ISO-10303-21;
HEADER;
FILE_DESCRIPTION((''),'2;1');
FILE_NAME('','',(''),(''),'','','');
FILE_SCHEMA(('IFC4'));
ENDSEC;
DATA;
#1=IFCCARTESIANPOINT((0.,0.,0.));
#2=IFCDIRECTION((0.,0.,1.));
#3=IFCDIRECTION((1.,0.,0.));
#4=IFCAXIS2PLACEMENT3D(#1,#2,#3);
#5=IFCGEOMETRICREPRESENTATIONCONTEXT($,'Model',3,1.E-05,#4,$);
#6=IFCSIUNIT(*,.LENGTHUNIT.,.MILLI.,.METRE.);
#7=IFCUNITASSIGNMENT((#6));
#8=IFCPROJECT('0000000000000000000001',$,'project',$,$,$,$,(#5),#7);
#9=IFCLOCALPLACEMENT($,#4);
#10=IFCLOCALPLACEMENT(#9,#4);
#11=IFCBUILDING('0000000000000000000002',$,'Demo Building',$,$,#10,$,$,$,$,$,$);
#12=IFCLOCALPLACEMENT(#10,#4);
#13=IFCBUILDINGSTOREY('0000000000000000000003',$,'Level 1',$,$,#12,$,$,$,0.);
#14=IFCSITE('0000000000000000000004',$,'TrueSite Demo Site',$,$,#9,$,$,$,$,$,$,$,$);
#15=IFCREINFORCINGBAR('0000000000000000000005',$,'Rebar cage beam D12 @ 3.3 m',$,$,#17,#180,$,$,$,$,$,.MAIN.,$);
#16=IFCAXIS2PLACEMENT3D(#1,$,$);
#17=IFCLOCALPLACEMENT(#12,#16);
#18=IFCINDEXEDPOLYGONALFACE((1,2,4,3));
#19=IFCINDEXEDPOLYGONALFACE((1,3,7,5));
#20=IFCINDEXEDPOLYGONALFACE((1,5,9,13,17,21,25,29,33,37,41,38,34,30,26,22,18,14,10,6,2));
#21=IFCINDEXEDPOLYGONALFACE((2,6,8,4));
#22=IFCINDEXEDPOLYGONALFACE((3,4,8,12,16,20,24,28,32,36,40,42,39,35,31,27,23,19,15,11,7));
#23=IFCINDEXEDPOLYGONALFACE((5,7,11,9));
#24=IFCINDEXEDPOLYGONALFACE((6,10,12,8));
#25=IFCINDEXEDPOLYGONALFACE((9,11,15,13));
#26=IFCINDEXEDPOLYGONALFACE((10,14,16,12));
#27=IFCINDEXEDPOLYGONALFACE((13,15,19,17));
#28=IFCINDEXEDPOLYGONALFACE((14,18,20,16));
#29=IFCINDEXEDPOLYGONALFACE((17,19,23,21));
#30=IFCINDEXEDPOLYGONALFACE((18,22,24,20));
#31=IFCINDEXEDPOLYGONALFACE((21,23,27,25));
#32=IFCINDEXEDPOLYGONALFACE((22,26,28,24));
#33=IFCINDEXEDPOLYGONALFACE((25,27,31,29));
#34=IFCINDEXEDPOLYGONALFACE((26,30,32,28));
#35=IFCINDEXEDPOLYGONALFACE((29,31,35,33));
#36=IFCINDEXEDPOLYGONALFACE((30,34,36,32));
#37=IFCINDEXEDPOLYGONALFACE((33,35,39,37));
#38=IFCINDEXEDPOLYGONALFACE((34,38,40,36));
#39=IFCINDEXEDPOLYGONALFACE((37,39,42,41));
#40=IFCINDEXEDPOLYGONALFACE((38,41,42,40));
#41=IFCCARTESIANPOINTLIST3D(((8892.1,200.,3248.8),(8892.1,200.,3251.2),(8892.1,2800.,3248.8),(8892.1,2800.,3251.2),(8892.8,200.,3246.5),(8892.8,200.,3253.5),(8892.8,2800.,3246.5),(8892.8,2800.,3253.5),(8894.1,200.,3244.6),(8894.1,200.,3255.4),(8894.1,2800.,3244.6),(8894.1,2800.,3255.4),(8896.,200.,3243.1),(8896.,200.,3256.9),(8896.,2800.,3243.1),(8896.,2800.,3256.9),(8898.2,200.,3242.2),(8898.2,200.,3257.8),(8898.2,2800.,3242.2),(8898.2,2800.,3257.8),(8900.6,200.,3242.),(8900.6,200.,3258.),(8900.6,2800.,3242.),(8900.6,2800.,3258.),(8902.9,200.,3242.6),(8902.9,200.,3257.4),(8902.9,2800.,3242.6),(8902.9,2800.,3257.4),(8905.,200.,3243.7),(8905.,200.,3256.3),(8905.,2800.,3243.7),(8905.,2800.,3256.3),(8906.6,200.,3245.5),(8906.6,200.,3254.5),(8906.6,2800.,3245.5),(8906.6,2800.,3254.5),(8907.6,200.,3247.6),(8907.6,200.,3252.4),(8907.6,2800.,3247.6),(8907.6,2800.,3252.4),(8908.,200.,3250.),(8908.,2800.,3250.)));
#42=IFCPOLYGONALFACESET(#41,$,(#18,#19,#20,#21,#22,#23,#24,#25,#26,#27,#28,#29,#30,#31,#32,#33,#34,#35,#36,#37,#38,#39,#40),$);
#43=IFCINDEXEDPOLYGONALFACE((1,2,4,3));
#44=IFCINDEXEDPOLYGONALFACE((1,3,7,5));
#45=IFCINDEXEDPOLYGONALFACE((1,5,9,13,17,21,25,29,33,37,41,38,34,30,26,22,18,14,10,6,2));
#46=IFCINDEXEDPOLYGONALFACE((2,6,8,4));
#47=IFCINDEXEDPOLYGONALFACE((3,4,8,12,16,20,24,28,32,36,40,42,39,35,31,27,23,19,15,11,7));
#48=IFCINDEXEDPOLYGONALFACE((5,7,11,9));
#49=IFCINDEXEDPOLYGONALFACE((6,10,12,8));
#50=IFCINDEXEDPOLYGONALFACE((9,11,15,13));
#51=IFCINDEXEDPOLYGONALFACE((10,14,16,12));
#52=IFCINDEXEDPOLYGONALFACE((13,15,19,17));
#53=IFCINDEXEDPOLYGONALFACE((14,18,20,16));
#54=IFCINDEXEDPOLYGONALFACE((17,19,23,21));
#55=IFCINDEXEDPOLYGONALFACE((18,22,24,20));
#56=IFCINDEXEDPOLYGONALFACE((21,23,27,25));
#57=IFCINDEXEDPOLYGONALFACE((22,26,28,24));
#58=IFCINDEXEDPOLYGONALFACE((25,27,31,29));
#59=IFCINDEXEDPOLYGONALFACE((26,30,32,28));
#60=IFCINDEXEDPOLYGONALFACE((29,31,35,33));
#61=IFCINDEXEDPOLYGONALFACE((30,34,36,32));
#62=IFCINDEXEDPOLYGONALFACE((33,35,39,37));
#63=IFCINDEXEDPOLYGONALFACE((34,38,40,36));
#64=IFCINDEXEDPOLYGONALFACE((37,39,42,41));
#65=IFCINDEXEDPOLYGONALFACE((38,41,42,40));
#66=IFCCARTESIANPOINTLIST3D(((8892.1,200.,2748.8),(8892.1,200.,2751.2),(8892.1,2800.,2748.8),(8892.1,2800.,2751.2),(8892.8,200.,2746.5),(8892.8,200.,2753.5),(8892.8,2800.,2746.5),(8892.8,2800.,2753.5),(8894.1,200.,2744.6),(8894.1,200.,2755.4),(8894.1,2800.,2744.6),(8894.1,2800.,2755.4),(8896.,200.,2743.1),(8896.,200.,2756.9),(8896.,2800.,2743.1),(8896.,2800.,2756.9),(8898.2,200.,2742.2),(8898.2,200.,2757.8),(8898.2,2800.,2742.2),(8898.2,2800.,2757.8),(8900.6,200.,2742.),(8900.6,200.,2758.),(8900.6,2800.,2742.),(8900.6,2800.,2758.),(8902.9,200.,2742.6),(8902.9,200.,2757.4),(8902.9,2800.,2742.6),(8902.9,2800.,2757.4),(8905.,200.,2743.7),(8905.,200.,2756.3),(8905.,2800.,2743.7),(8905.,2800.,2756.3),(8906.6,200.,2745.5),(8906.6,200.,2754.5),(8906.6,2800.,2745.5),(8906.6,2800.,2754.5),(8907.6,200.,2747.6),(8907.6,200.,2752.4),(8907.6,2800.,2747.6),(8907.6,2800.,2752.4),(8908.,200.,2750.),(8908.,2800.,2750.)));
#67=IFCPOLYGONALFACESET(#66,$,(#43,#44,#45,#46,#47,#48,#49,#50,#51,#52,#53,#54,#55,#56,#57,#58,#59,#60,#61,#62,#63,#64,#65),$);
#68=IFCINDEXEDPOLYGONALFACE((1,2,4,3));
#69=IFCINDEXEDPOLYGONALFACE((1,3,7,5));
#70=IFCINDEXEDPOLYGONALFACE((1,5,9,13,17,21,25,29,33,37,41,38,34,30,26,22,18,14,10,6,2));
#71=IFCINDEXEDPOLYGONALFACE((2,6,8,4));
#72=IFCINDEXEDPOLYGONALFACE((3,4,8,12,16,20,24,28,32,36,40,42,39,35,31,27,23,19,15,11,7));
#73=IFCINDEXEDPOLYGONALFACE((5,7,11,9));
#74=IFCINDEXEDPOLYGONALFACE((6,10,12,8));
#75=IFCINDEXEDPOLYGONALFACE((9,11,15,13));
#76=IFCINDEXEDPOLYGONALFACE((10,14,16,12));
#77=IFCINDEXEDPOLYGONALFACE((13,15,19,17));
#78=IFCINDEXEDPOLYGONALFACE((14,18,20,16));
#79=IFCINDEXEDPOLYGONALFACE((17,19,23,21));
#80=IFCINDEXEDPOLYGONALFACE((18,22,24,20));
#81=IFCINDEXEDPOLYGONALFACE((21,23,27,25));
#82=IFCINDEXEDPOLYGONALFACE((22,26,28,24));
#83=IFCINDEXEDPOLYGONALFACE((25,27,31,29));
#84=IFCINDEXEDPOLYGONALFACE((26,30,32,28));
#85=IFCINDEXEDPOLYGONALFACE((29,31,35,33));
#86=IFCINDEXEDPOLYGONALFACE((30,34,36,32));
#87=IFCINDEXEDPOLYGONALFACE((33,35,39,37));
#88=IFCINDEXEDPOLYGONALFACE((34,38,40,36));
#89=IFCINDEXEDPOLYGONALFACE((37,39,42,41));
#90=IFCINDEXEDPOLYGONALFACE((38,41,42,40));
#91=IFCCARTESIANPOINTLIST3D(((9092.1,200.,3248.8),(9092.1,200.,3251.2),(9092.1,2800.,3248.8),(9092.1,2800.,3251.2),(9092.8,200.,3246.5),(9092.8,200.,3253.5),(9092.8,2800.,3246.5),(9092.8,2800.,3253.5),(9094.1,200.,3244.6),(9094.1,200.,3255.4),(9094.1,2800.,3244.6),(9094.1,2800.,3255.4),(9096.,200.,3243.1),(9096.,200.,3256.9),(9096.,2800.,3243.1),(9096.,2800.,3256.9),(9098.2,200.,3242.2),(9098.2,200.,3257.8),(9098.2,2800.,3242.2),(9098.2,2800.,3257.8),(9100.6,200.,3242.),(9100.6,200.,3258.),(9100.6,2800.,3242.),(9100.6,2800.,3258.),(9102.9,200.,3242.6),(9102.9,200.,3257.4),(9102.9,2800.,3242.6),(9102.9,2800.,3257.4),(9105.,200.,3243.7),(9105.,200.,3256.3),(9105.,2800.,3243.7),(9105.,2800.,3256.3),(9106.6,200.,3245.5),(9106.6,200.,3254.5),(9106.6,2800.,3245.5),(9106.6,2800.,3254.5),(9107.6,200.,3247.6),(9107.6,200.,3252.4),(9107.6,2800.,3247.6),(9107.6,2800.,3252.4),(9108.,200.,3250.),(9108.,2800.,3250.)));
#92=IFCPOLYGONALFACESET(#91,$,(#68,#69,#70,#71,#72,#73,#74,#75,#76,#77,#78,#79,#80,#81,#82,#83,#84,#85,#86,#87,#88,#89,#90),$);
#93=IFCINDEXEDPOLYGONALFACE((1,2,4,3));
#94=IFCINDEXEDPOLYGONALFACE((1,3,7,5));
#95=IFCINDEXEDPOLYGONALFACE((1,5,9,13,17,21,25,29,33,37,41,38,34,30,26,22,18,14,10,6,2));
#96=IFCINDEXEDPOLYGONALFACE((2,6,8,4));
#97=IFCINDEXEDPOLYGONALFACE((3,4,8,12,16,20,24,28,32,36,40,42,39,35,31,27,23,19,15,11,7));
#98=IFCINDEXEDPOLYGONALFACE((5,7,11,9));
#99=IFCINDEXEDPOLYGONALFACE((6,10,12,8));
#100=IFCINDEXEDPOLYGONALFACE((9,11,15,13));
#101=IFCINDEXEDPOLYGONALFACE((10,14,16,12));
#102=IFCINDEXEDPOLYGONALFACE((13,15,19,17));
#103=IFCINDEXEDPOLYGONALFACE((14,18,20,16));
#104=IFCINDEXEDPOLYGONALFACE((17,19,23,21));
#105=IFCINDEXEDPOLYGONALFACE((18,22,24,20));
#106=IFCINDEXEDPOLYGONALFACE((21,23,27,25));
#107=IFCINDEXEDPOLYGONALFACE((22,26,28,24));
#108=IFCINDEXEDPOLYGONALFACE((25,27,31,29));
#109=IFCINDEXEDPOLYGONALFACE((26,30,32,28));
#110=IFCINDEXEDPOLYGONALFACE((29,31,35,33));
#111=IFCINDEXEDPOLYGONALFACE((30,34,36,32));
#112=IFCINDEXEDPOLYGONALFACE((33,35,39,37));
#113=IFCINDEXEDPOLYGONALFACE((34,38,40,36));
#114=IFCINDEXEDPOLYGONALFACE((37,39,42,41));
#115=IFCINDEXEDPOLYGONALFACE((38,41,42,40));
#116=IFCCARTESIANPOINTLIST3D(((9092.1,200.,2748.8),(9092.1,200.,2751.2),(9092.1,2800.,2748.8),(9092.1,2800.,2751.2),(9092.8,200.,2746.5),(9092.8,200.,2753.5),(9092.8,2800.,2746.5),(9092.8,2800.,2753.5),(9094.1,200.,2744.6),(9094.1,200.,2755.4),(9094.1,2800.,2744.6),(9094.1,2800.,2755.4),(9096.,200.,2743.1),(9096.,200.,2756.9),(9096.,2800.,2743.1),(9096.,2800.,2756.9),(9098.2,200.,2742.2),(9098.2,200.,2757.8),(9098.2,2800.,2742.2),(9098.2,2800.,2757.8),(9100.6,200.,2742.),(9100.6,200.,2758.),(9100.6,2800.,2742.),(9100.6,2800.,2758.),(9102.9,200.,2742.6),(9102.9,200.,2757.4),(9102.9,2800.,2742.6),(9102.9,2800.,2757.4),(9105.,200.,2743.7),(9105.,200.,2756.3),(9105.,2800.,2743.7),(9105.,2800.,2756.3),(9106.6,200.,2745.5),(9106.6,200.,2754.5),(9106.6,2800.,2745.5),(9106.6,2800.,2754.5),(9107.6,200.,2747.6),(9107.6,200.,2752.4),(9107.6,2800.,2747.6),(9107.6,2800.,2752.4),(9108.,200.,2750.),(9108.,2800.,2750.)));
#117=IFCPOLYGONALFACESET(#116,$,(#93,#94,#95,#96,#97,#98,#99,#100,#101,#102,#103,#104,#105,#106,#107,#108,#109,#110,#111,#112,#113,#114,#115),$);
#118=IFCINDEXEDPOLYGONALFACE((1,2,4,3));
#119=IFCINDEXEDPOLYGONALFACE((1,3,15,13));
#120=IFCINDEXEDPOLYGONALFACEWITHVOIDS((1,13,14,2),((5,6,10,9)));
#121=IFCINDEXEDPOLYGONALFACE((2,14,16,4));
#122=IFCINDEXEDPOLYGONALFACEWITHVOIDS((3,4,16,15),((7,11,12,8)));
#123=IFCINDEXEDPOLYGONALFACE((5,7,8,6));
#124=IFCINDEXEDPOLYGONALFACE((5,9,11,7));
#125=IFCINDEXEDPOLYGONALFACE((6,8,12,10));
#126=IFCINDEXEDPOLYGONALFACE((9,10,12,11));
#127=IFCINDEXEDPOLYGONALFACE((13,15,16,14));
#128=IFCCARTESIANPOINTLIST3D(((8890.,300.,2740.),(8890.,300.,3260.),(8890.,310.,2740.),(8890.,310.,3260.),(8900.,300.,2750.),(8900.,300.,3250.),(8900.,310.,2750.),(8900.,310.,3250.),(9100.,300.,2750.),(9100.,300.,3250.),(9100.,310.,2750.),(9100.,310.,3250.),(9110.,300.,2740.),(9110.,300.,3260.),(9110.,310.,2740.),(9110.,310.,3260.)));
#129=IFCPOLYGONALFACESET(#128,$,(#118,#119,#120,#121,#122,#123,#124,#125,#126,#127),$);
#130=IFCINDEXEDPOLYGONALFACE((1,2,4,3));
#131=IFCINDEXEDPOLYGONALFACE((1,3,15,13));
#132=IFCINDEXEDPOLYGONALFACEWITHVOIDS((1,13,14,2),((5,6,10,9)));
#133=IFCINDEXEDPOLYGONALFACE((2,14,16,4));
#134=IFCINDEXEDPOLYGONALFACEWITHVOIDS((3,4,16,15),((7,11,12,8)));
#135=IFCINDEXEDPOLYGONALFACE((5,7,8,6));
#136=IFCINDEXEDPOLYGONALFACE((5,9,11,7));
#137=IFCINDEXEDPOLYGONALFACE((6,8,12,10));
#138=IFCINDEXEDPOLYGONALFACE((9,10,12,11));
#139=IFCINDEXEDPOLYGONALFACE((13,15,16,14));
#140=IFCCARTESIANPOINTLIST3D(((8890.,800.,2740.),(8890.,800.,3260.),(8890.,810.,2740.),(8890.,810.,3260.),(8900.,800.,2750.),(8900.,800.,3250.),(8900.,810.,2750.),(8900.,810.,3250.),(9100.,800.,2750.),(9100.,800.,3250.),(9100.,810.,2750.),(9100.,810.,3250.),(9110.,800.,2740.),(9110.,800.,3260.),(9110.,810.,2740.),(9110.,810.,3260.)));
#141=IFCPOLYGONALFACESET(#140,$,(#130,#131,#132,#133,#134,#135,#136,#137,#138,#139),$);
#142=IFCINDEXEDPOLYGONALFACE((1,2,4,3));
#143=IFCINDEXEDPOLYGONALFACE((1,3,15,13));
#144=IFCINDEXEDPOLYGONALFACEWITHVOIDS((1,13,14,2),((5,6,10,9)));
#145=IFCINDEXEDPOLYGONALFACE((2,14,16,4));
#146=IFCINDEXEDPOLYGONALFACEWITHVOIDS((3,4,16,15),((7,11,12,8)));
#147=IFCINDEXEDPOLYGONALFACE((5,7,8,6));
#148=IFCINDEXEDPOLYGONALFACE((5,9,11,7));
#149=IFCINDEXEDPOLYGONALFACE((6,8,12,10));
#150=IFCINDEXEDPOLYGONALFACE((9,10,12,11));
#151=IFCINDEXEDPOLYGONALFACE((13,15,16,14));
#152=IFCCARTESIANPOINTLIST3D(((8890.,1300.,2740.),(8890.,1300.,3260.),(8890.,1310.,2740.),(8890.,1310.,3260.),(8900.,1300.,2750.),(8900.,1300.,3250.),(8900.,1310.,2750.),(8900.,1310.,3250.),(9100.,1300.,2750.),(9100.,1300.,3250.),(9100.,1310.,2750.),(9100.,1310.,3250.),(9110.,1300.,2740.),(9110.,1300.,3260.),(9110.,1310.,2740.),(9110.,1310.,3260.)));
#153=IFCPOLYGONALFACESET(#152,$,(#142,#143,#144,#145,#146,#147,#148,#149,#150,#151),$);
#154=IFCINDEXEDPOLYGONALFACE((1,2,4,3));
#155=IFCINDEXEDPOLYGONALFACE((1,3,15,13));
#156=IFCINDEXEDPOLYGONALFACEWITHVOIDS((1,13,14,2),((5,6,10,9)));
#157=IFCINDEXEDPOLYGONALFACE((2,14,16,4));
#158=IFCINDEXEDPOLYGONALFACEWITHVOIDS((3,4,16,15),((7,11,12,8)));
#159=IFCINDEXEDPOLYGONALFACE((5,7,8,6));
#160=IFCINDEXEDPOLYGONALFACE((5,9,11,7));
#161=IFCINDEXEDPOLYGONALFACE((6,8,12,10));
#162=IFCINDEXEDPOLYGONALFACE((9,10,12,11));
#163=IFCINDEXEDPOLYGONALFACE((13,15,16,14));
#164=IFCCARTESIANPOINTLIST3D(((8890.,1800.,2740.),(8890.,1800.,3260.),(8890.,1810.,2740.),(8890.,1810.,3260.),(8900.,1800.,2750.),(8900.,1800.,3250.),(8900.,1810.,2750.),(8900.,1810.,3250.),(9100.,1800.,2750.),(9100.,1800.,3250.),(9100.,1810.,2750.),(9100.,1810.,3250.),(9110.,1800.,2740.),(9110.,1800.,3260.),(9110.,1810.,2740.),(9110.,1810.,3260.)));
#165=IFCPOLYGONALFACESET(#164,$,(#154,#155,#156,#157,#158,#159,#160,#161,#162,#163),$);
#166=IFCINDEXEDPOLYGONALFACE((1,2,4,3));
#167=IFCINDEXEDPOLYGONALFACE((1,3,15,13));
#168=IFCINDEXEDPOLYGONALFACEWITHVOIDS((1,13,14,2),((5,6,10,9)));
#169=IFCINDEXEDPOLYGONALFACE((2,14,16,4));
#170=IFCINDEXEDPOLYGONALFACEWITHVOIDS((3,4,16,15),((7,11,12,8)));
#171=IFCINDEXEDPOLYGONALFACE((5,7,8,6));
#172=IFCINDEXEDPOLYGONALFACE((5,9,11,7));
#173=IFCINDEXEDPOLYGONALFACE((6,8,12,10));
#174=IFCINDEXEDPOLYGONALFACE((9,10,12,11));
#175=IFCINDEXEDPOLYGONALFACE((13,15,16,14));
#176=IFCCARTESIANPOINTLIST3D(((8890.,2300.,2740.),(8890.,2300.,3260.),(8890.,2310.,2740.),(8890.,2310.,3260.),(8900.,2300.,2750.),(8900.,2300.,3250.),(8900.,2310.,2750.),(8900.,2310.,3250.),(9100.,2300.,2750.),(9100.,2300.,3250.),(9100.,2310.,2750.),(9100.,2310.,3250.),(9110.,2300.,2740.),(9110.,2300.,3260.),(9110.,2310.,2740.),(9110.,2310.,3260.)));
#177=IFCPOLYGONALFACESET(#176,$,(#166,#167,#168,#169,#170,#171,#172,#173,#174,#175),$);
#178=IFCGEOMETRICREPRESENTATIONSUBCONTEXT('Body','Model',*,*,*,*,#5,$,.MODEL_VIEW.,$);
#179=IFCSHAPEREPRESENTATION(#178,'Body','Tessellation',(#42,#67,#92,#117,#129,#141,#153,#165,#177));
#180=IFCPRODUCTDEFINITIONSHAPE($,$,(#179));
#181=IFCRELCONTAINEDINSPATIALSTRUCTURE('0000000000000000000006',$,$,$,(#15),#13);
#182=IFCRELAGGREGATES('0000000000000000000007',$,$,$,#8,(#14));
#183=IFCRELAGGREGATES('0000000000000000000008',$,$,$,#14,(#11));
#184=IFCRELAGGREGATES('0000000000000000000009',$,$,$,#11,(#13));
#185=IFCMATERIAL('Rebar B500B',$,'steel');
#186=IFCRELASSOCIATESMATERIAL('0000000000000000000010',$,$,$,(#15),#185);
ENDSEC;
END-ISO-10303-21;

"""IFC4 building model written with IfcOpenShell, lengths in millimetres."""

from ifc_helpers import new_model, si_unit, frame, origin_with_axes, place, context, subcontext, project, spatial, hollow_rectangle, circle, extrude, material, element, save


model = new_model("IFC4")

# Units and contexts
model_context = context("Model", 3, precision=1e-05, world=origin_with_axes())
body_context = subcontext(model_context, "Body", "Model", "MODEL_VIEW")
ifc_project = project(units=[si_unit("LENGTHUNIT", "METRE", prefix="MILLI")], contexts=[model_context])

# Site, building, storey
site_placement = place(None, origin_with_axes())
site = spatial("IfcSite", under=ifc_project, at=site_placement, Name="TrueSite Demo Site")
building_placement = place(site_placement, origin_with_axes())
building = spatial("IfcBuilding", under=site, at=building_placement, Name="Demo Building")
storey_placement = place(building_placement, origin_with_axes())
storey = spatial("IfcBuildingStorey", under=building, at=storey_placement, Name="Level 1", Elevation=0.0)

# Reinforcing bar
ifc_material_1 = material(Name="Rebar B500B", Category="steel")
for number, where, z_axis, x_axis, name in (
    (1, (9000.0, 200.0, 3000.0), (0.0, 1.0, 0.0), (1.0, 0.0, 0.0), "Rebar cage beam D12 @ 3.3 m"),
):
    element("IfcReinforcingBar", number, at=place(storey_placement, frame(where, z_axis=z_axis, x_axis=x_axis)), inside=storey, material=ifc_material_1, Name=name, PredefinedType="MAIN", context=body_context, shape_type="SweptSolid", body=[
        extrude(circle(Radius=8.0), frame((-100.0, -250.0, 0.0)), (0.0, 0.0, 1.0), 2600.0),
        extrude(circle(Radius=8.0), frame((-100.0, 250.0, 0.0)), (0.0, 0.0, 1.0), 2600.0),
        extrude(circle(Radius=8.0), frame((100.0, -250.0, 0.0)), (0.0, 0.0, 1.0), 2600.0),
        extrude(circle(Radius=8.0), frame((100.0, 250.0, 0.0)), (0.0, 0.0, 1.0), 2600.0),
        extrude(hollow_rectangle(XDim=220.0, YDim=520.0, WallThickness=10.0), frame((0.0, 0.0, 100.0)), (0.0, 0.0, 1.0), 10.0),
        extrude(hollow_rectangle(XDim=220.0, YDim=520.0, WallThickness=10.0), frame((0.0, 0.0, 600.0)), (0.0, 0.0, 1.0), 10.0),
        extrude(hollow_rectangle(XDim=220.0, YDim=520.0, WallThickness=10.0), frame((0.0, 0.0, 1100.0)), (0.0, 0.0, 1.0), 10.0),
        extrude(hollow_rectangle(XDim=220.0, YDim=520.0, WallThickness=10.0), frame((0.0, 0.0, 1600.0)), (0.0, 0.0, 1.0), 10.0),
        extrude(hollow_rectangle(XDim=220.0, YDim=520.0, WallThickness=10.0), frame((0.0, 0.0, 2100.0)), (0.0, 0.0, 1.0), 10.0),
    ])

save(model, "model.ifc")
